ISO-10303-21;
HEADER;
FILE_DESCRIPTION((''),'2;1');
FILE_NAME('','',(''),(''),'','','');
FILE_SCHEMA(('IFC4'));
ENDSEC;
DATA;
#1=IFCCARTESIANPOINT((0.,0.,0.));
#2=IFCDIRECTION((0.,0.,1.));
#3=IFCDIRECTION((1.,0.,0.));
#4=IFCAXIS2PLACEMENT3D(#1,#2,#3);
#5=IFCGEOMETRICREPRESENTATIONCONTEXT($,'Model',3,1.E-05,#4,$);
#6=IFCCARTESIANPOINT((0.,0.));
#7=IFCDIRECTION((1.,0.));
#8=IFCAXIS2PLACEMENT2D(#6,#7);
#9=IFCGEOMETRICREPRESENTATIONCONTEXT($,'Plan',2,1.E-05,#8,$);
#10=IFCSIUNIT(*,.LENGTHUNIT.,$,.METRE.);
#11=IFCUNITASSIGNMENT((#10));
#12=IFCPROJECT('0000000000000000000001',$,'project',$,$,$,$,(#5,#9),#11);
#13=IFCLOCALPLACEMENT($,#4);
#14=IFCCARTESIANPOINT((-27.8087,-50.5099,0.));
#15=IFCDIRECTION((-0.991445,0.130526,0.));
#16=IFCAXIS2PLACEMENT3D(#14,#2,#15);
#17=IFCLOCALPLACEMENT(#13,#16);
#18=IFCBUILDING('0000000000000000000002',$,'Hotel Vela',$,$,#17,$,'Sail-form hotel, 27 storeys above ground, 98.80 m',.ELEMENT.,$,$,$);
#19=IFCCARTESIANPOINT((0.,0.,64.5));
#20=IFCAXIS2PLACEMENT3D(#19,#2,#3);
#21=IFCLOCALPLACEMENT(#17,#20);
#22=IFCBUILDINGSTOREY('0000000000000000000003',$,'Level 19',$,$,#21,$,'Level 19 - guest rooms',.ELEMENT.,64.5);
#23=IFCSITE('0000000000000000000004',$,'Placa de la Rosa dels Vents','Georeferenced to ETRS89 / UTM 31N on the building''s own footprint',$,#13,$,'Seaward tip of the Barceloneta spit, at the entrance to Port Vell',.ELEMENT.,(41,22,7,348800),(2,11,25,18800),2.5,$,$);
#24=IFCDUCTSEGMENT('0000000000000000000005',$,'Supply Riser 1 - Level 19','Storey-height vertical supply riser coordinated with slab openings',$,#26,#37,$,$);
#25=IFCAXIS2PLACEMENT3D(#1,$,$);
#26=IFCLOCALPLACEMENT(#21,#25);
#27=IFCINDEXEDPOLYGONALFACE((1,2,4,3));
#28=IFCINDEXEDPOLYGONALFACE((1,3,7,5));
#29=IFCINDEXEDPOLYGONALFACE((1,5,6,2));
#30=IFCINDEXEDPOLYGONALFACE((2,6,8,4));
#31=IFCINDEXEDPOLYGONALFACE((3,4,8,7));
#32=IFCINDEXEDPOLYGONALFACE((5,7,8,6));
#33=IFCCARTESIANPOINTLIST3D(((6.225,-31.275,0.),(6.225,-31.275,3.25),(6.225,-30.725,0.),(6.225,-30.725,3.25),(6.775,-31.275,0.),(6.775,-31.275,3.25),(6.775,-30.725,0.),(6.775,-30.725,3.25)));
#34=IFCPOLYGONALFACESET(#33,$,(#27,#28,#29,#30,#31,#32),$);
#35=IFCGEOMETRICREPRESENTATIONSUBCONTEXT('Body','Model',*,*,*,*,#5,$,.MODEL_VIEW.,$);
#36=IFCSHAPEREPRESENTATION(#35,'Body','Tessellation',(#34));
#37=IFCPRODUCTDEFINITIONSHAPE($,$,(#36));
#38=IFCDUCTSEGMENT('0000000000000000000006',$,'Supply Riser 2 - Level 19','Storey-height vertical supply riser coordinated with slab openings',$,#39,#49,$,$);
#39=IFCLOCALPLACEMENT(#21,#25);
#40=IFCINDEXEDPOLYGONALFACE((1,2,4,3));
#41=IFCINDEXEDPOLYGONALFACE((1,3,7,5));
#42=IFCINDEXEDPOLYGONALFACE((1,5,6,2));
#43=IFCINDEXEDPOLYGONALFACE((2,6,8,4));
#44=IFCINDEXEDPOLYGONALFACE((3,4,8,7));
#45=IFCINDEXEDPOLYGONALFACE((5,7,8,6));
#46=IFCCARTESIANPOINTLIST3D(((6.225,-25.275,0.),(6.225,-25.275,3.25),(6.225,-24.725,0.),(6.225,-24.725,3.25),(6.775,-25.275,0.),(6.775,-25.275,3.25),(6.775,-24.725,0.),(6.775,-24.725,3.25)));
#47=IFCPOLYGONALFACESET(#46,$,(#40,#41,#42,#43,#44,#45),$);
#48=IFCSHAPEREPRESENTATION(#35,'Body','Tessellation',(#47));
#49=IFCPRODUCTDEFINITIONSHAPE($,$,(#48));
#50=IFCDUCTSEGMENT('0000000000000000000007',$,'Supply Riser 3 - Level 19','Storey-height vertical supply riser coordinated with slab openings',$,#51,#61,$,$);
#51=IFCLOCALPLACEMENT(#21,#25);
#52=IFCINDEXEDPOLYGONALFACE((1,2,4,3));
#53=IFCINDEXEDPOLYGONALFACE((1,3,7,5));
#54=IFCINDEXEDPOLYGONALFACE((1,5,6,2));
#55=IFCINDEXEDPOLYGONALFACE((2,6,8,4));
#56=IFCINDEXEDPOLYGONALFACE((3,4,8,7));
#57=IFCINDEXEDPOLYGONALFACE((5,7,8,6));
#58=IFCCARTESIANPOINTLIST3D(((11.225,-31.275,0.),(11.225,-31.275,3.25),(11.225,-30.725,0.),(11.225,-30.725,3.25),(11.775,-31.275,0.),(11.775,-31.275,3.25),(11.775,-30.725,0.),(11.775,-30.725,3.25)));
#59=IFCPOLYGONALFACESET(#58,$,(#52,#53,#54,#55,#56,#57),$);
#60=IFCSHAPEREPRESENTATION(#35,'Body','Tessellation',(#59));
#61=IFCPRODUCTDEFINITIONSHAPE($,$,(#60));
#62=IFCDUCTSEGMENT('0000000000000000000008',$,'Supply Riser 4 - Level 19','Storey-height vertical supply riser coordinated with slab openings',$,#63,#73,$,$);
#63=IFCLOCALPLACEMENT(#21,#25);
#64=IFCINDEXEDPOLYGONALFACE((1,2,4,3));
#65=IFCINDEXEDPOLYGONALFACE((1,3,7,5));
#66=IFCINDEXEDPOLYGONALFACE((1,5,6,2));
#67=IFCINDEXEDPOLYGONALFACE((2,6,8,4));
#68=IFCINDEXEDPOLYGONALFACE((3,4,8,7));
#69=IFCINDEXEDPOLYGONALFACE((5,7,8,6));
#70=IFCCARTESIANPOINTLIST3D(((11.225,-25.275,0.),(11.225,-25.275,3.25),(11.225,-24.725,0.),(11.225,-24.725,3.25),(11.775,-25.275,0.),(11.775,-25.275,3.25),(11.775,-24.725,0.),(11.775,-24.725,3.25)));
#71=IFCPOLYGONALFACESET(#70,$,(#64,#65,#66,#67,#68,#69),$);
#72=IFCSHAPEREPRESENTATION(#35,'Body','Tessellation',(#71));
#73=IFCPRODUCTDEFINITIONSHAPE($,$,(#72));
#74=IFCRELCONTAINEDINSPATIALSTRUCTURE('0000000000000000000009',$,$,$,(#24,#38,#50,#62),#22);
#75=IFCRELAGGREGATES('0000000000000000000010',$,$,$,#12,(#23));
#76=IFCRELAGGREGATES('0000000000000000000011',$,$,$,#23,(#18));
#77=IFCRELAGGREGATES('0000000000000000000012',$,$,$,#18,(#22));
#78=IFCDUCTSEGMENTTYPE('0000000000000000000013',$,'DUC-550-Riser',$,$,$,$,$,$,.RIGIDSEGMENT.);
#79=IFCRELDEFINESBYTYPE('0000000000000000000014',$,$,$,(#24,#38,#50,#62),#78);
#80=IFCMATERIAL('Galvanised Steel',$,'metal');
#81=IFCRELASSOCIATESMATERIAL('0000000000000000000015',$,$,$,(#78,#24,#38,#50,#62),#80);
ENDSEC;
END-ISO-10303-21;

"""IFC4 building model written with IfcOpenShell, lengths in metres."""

from ifc_helpers import new_model, si_unit, frame, origin_with_axes, origin_2d_with_axis, place, context, subcontext, project, spatial, line, indexed_curve, outline, extrude, material, type_object, element, save


model = new_model("IFC4")

# Units and contexts
model_context = context("Model", 3, precision=1e-05, world=origin_with_axes())
plan_context = context("Plan", 2, precision=1e-05, world=origin_2d_with_axis())
body_context = subcontext(model_context, "Body", "Model", "MODEL_VIEW")
ifc_project = project(units=[si_unit("LENGTHUNIT", "METRE")], contexts=[model_context, plan_context])

# Site, building, storey
site_placement = place(None, origin_with_axes())
site = spatial("IfcSite", under=ifc_project, at=site_placement, Name="Placa de la Rosa dels Vents", Description="Georeferenced to ETRS89 / UTM 31N on the building's own footprint", LongName="Seaward tip of the Barceloneta spit, at the entrance to Port Vell", CompositionType="ELEMENT", RefLatitude=(41, 22, 7, 348800), RefLongitude=(2, 11, 25, 18800), RefElevation=2.5)
building_placement = place(site_placement, frame((-27.8087, -50.5099, 0.0), z_axis=(0.0, 0.0, 1.0), x_axis=(-0.991445, 0.130526, 0.0)))
building = spatial("IfcBuilding", under=site, at=building_placement, Name="Hotel Vela", LongName="Sail-form hotel, 27 storeys above ground, 98.80 m", CompositionType="ELEMENT")
storey_placement = place(building_placement, frame((0.0, 0.0, 64.5), z_axis=(0.0, 0.0, 1.0), x_axis=(1.0, 0.0, 0.0)))
storey = spatial("IfcBuildingStorey", under=building, at=storey_placement, Name="Level 19", LongName="Level 19 - guest rooms", CompositionType="ELEMENT", Elevation=64.5)

# Duct segments
ifc_material = material(Name="Galvanised Steel", Category="metal")
duct_segment_type = type_object("IfcDuctSegmentType", Name="DUC-550-Riser", PredefinedType="RIGIDSEGMENT", material=ifc_material)
for number, where, z_axis, x_axis, name in (
    (1, (6.225, -31.275, 0.0), (0.0, 0.0, 1.0), (1.0, 0.0, 0.0), "Supply Riser 1 - Level 19"),
    (2, (6.225, -25.275, 0.0), (0.0, 0.0, 1.0), (1.0, 0.0, 0.0), "Supply Riser 2 - Level 19"),
    (3, (11.225, -31.275, 0.0), (0.0, 0.0, 1.0), (1.0, 0.0, 0.0), "Supply Riser 3 - Level 19"),
    (4, (11.225, -25.275, 0.0), (0.0, 0.0, 1.0), (1.0, 0.0, 0.0), "Supply Riser 4 - Level 19"),
):
    element("IfcDuctSegment", number, at=place(storey_placement, frame(where, z_axis=z_axis, x_axis=x_axis)), inside=storey, type_object=duct_segment_type, material=ifc_material, Name=name, Description="Storey-height vertical supply riser coordinated with slab openings", context=body_context, shape_type="SweptSolid", body=[
        extrude(outline(indexed_curve([(0.0, 0.0), (0.55, 0.0), (0.55, 0.55), (0.0, 0.55)], segments=[line(1, 2, 3, 4, 1)])), origin_with_axes(), (0.0, 0.0, 1.0), 3.25),
    ])

save(model, "model.ifc")
